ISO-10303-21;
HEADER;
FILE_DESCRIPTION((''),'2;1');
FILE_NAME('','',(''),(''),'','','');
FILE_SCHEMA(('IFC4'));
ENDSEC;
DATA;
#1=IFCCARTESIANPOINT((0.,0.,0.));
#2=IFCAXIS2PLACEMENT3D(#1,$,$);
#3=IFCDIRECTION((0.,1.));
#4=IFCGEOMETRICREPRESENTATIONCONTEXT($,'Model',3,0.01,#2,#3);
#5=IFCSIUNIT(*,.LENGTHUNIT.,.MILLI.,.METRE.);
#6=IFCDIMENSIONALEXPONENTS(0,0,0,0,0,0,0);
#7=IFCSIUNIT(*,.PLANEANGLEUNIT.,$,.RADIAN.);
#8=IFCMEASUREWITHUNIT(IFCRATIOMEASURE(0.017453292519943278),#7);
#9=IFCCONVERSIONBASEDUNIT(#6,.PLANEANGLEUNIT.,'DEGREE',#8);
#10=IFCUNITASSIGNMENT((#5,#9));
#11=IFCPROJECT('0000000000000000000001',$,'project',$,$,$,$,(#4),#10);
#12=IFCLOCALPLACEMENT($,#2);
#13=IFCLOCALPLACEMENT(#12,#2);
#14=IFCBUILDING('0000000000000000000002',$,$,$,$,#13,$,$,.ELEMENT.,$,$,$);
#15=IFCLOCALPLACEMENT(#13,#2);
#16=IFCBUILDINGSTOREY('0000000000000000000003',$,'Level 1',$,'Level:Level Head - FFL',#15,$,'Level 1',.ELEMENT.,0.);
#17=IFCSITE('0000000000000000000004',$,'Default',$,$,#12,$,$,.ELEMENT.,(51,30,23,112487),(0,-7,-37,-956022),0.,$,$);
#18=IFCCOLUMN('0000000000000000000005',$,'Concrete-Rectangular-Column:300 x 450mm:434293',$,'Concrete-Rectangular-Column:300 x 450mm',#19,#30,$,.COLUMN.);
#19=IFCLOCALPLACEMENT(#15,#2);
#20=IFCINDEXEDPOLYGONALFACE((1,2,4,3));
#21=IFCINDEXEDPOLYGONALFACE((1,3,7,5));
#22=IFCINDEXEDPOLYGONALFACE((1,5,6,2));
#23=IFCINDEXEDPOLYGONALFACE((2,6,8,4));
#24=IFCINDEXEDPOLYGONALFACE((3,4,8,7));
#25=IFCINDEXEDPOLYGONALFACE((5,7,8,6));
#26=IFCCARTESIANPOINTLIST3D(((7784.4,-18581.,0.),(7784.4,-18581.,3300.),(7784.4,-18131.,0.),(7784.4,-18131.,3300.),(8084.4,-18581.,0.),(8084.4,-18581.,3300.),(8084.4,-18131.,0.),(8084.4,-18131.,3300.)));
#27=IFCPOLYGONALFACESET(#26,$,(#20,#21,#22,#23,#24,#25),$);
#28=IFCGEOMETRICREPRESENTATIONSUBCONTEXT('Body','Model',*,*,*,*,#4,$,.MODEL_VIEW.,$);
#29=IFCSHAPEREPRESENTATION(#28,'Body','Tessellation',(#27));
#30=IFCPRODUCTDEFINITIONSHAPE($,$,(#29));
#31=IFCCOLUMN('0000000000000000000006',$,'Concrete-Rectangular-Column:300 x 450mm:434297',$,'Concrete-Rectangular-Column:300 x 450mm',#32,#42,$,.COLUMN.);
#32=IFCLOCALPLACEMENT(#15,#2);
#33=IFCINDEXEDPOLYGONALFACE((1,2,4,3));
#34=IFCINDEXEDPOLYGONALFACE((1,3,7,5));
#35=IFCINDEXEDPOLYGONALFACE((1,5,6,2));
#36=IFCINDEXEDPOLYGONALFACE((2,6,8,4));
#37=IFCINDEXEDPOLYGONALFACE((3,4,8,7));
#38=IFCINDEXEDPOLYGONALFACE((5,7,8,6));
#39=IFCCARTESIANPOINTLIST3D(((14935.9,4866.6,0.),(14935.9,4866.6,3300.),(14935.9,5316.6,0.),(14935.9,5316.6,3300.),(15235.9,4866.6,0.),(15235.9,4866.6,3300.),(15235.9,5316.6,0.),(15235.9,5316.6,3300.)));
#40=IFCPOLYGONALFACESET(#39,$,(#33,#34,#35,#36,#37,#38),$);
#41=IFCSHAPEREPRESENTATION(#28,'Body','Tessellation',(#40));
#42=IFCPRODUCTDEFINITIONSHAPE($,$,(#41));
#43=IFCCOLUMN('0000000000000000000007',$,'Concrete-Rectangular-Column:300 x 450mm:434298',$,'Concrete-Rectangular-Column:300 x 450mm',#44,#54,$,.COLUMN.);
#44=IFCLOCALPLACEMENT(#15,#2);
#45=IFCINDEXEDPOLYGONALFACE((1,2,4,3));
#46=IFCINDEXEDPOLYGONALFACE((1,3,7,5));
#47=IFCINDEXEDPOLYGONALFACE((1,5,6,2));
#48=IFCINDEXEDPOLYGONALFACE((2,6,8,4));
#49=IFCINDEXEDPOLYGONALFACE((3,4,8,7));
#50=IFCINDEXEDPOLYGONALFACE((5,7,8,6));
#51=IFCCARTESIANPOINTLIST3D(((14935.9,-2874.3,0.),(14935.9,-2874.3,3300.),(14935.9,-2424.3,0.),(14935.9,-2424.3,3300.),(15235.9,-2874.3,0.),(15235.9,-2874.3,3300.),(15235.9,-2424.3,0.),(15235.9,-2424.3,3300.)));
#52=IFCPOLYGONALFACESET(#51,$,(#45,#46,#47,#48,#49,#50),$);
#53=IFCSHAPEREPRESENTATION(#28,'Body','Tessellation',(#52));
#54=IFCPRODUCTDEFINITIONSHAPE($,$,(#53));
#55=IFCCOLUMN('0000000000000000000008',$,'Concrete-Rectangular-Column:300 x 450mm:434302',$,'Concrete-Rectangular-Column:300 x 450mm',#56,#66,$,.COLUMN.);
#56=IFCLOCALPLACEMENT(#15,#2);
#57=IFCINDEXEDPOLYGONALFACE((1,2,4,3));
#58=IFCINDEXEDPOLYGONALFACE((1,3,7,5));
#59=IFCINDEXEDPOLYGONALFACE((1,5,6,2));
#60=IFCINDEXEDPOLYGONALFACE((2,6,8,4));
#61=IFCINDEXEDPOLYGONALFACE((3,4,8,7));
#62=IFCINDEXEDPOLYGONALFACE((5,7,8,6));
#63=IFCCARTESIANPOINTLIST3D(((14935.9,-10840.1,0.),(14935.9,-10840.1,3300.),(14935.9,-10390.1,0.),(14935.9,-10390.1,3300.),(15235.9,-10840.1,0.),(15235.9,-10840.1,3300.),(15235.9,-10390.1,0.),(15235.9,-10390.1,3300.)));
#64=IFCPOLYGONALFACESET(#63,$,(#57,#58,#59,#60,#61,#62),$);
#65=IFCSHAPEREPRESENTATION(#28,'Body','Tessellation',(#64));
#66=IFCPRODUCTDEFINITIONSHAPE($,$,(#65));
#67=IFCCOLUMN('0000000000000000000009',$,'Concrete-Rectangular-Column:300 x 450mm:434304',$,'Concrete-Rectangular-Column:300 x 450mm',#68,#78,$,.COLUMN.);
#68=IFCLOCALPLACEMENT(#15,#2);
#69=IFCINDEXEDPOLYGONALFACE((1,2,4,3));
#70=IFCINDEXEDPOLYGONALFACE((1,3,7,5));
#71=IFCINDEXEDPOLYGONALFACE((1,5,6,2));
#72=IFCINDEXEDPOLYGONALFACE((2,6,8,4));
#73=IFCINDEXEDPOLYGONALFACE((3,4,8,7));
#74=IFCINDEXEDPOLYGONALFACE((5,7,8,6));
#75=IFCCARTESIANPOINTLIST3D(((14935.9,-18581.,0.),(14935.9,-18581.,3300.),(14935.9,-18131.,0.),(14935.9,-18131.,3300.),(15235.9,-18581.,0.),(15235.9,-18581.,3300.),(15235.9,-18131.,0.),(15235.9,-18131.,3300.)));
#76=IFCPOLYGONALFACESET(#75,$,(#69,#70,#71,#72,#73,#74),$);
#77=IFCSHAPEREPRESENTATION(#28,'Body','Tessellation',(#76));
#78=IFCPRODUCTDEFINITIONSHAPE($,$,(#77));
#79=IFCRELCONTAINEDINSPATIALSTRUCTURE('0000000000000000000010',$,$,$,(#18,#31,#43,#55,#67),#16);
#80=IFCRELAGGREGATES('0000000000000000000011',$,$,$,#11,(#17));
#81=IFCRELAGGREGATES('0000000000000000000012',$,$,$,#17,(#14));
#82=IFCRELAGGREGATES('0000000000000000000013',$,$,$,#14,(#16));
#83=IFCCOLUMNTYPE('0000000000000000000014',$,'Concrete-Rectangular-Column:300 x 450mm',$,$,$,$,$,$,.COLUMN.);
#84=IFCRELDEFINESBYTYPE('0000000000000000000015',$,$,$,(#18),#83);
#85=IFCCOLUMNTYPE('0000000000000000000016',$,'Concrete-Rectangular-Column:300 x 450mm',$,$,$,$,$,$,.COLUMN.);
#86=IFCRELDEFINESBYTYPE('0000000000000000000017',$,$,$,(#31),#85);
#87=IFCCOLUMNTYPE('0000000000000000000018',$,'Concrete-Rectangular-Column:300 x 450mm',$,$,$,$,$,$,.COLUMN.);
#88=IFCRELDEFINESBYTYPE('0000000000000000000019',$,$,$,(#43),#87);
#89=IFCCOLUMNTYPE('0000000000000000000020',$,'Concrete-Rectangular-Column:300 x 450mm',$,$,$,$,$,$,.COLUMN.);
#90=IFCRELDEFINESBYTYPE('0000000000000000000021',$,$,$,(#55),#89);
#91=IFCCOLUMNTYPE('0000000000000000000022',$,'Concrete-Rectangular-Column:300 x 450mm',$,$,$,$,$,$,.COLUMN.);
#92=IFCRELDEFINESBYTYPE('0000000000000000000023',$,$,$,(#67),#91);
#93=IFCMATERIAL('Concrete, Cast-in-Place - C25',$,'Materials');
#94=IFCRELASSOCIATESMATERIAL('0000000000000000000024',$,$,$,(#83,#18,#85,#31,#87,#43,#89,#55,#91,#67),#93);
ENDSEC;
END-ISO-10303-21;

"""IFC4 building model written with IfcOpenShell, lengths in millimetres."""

from ifc_helpers import new_model, entity, si_unit, converted_unit, direction, frame, origin, place, context, subcontext, project, spatial, indexed_curve, outline, extrude, source, transform, mapped, material, type_object, type_shapes, element, save


model = new_model("IFC4")

# Units and contexts
model_context = context("Model", 3, precision=0.01, world=origin(), true_north=direction((0.0, 1.0)))
body_context = subcontext(model_context, "Body", "Model", "MODEL_VIEW")
ifc_project = project(units=[si_unit("LENGTHUNIT", "METRE", prefix="MILLI"), converted_unit("PLANEANGLEUNIT", "DEGREE", entity("IfcRatioMeasure", 0.017453292519943278), si_unit("PLANEANGLEUNIT", "RADIAN"), dimensions=[0, 0, 0, 0, 0, 0, 0])], contexts=[model_context])

# Site, building, storey
site_placement = place(None, origin())
site = spatial("IfcSite", under=ifc_project, at=site_placement, Name="Default", CompositionType="ELEMENT", RefLatitude=(51, 30, 23, 112487), RefLongitude=(0, -7, -37, -956022), RefElevation=0.0)
building_placement = place(site_placement, origin())
building = spatial("IfcBuilding", under=site, at=building_placement, CompositionType="ELEMENT")
storey_placement = place(building_placement, origin())
storey = spatial("IfcBuildingStorey", under=building, at=storey_placement, Name="Level 1", ObjectType="Level:Level Head - FFL", LongName="Level 1", CompositionType="ELEMENT", Elevation=0.0)

# Columns
ifc_material = material(Name="Concrete, Cast-in-Place - C25", Category="Materials")
column_type_1 = type_object("IfcColumnType", Name="Concrete-Rectangular-Column:300 x 450mm", PredefinedType="COLUMN", material=ifc_material)
shared_shape_1 = source(origin(), body_context, "Body", "SweptSolid", [
    extrude(outline(indexed_curve([(-225.0, -150.0), (225.0, -150.0), (225.0, 150.0), (-225.0, 150.0), (-225.0, -150.0)], self_intersect=False)), frame((7934.4, -18356.0, 0.0), z_axis=(0.0, 0.0, 1.0), x_axis=(0.0, -1.0, 0.0)), (0.0, 0.0, 1.0), 3300.0),
])
type_shapes(column_type_1, [shared_shape_1])
column_1_placement = place(storey_placement, origin())
element("IfcColumn", 1, at=column_1_placement, inside=storey, type_object=column_type_1, material=ifc_material, Name="Concrete-Rectangular-Column:300 x 450mm:434293", ObjectType="Concrete-Rectangular-Column:300 x 450mm", PredefinedType="COLUMN", context=body_context, shape_type="MappedRepresentation", body=[
    mapped(shared_shape_1, transform((0.0, 0.0, 0.0), scale=1.0)),
])
column_type_2 = type_object("IfcColumnType", Name="Concrete-Rectangular-Column:300 x 450mm", PredefinedType="COLUMN", material=ifc_material)
shared_shape_2 = source(origin(), body_context, "Body", "SweptSolid", [
    extrude(outline(indexed_curve([(-225.0, -150.0), (225.0, -150.0), (225.0, 150.0), (-225.0, 150.0), (-225.0, -150.0)], self_intersect=False)), frame((15085.9, 5091.6, 0.0), z_axis=(0.0, 0.0, 1.0), x_axis=(0.0, -1.0, 0.0)), (0.0, 0.0, 1.0), 3300.0),
])
type_shapes(column_type_2, [shared_shape_2])
column_2_placement = place(storey_placement, origin())
element("IfcColumn", 2, at=column_2_placement, inside=storey, type_object=column_type_2, material=ifc_material, Name="Concrete-Rectangular-Column:300 x 450mm:434297", ObjectType="Concrete-Rectangular-Column:300 x 450mm", PredefinedType="COLUMN", context=body_context, shape_type="MappedRepresentation", body=[
    mapped(shared_shape_2, transform((0.0, 0.0, 0.0), scale=1.0)),
])
column_type_3 = type_object("IfcColumnType", Name="Concrete-Rectangular-Column:300 x 450mm", PredefinedType="COLUMN", material=ifc_material)
shared_shape_3 = source(origin(), body_context, "Body", "SweptSolid", [
    extrude(outline(indexed_curve([(-225.0, -150.0), (225.0, -150.0), (225.0, 150.0), (-225.0, 150.0), (-225.0, -150.0)], self_intersect=False)), frame((15085.9, -2649.3, 0.0), z_axis=(0.0, 0.0, 1.0), x_axis=(0.0, -1.0, 0.0)), (0.0, 0.0, 1.0), 3300.0),
])
type_shapes(column_type_3, [shared_shape_3])
column_3_placement = place(storey_placement, origin())
element("IfcColumn", 3, at=column_3_placement, inside=storey, type_object=column_type_3, material=ifc_material, Name="Concrete-Rectangular-Column:300 x 450mm:434298", ObjectType="Concrete-Rectangular-Column:300 x 450mm", PredefinedType="COLUMN", context=body_context, shape_type="MappedRepresentation", body=[
    mapped(shared_shape_3, transform((0.0, 0.0, 0.0), scale=1.0)),
])
column_type_4 = type_object("IfcColumnType", Name="Concrete-Rectangular-Column:300 x 450mm", PredefinedType="COLUMN", material=ifc_material)
shared_shape_4 = source(origin(), body_context, "Body", "SweptSolid", [
    extrude(outline(indexed_curve([(-225.0, -150.0), (225.0, -150.0), (225.0, 150.0), (-225.0, 150.0), (-225.0, -150.0)], self_intersect=False)), frame((15085.9, -10615.1, 0.0), z_axis=(0.0, 0.0, 1.0), x_axis=(0.0, -1.0, 0.0)), (0.0, 0.0, 1.0), 3300.0),
])
type_shapes(column_type_4, [shared_shape_4])
column_4_placement = place(storey_placement, origin())
element("IfcColumn", 4, at=column_4_placement, inside=storey, type_object=column_type_4, material=ifc_material, Name="Concrete-Rectangular-Column:300 x 450mm:434302", ObjectType="Concrete-Rectangular-Column:300 x 450mm", PredefinedType="COLUMN", context=body_context, shape_type="MappedRepresentation", body=[
    mapped(shared_shape_4, transform((0.0, 0.0, 0.0), scale=1.0)),
])
column_type_5 = type_object("IfcColumnType", Name="Concrete-Rectangular-Column:300 x 450mm", PredefinedType="COLUMN", material=ifc_material)
shared_shape_5 = source(origin(), body_context, "Body", "SweptSolid", [
    extrude(outline(indexed_curve([(-225.0, -150.0), (225.0, -150.0), (225.0, 150.0), (-225.0, 150.0), (-225.0, -150.0)], self_intersect=False)), frame((15085.9, -18356.0, 0.0), z_axis=(0.0, 0.0, 1.0), x_axis=(0.0, -1.0, 0.0)), (0.0, 0.0, 1.0), 3300.0),
])
type_shapes(column_type_5, [shared_shape_5])
column_5_placement = place(storey_placement, origin())
element("IfcColumn", 5, at=column_5_placement, inside=storey, type_object=column_type_5, material=ifc_material, Name="Concrete-Rectangular-Column:300 x 450mm:434304", ObjectType="Concrete-Rectangular-Column:300 x 450mm", PredefinedType="COLUMN", context=body_context, shape_type="MappedRepresentation", body=[
    mapped(shared_shape_5, transform((0.0, 0.0, 0.0), scale=1.0)),
])

save(model, "model.ifc")
